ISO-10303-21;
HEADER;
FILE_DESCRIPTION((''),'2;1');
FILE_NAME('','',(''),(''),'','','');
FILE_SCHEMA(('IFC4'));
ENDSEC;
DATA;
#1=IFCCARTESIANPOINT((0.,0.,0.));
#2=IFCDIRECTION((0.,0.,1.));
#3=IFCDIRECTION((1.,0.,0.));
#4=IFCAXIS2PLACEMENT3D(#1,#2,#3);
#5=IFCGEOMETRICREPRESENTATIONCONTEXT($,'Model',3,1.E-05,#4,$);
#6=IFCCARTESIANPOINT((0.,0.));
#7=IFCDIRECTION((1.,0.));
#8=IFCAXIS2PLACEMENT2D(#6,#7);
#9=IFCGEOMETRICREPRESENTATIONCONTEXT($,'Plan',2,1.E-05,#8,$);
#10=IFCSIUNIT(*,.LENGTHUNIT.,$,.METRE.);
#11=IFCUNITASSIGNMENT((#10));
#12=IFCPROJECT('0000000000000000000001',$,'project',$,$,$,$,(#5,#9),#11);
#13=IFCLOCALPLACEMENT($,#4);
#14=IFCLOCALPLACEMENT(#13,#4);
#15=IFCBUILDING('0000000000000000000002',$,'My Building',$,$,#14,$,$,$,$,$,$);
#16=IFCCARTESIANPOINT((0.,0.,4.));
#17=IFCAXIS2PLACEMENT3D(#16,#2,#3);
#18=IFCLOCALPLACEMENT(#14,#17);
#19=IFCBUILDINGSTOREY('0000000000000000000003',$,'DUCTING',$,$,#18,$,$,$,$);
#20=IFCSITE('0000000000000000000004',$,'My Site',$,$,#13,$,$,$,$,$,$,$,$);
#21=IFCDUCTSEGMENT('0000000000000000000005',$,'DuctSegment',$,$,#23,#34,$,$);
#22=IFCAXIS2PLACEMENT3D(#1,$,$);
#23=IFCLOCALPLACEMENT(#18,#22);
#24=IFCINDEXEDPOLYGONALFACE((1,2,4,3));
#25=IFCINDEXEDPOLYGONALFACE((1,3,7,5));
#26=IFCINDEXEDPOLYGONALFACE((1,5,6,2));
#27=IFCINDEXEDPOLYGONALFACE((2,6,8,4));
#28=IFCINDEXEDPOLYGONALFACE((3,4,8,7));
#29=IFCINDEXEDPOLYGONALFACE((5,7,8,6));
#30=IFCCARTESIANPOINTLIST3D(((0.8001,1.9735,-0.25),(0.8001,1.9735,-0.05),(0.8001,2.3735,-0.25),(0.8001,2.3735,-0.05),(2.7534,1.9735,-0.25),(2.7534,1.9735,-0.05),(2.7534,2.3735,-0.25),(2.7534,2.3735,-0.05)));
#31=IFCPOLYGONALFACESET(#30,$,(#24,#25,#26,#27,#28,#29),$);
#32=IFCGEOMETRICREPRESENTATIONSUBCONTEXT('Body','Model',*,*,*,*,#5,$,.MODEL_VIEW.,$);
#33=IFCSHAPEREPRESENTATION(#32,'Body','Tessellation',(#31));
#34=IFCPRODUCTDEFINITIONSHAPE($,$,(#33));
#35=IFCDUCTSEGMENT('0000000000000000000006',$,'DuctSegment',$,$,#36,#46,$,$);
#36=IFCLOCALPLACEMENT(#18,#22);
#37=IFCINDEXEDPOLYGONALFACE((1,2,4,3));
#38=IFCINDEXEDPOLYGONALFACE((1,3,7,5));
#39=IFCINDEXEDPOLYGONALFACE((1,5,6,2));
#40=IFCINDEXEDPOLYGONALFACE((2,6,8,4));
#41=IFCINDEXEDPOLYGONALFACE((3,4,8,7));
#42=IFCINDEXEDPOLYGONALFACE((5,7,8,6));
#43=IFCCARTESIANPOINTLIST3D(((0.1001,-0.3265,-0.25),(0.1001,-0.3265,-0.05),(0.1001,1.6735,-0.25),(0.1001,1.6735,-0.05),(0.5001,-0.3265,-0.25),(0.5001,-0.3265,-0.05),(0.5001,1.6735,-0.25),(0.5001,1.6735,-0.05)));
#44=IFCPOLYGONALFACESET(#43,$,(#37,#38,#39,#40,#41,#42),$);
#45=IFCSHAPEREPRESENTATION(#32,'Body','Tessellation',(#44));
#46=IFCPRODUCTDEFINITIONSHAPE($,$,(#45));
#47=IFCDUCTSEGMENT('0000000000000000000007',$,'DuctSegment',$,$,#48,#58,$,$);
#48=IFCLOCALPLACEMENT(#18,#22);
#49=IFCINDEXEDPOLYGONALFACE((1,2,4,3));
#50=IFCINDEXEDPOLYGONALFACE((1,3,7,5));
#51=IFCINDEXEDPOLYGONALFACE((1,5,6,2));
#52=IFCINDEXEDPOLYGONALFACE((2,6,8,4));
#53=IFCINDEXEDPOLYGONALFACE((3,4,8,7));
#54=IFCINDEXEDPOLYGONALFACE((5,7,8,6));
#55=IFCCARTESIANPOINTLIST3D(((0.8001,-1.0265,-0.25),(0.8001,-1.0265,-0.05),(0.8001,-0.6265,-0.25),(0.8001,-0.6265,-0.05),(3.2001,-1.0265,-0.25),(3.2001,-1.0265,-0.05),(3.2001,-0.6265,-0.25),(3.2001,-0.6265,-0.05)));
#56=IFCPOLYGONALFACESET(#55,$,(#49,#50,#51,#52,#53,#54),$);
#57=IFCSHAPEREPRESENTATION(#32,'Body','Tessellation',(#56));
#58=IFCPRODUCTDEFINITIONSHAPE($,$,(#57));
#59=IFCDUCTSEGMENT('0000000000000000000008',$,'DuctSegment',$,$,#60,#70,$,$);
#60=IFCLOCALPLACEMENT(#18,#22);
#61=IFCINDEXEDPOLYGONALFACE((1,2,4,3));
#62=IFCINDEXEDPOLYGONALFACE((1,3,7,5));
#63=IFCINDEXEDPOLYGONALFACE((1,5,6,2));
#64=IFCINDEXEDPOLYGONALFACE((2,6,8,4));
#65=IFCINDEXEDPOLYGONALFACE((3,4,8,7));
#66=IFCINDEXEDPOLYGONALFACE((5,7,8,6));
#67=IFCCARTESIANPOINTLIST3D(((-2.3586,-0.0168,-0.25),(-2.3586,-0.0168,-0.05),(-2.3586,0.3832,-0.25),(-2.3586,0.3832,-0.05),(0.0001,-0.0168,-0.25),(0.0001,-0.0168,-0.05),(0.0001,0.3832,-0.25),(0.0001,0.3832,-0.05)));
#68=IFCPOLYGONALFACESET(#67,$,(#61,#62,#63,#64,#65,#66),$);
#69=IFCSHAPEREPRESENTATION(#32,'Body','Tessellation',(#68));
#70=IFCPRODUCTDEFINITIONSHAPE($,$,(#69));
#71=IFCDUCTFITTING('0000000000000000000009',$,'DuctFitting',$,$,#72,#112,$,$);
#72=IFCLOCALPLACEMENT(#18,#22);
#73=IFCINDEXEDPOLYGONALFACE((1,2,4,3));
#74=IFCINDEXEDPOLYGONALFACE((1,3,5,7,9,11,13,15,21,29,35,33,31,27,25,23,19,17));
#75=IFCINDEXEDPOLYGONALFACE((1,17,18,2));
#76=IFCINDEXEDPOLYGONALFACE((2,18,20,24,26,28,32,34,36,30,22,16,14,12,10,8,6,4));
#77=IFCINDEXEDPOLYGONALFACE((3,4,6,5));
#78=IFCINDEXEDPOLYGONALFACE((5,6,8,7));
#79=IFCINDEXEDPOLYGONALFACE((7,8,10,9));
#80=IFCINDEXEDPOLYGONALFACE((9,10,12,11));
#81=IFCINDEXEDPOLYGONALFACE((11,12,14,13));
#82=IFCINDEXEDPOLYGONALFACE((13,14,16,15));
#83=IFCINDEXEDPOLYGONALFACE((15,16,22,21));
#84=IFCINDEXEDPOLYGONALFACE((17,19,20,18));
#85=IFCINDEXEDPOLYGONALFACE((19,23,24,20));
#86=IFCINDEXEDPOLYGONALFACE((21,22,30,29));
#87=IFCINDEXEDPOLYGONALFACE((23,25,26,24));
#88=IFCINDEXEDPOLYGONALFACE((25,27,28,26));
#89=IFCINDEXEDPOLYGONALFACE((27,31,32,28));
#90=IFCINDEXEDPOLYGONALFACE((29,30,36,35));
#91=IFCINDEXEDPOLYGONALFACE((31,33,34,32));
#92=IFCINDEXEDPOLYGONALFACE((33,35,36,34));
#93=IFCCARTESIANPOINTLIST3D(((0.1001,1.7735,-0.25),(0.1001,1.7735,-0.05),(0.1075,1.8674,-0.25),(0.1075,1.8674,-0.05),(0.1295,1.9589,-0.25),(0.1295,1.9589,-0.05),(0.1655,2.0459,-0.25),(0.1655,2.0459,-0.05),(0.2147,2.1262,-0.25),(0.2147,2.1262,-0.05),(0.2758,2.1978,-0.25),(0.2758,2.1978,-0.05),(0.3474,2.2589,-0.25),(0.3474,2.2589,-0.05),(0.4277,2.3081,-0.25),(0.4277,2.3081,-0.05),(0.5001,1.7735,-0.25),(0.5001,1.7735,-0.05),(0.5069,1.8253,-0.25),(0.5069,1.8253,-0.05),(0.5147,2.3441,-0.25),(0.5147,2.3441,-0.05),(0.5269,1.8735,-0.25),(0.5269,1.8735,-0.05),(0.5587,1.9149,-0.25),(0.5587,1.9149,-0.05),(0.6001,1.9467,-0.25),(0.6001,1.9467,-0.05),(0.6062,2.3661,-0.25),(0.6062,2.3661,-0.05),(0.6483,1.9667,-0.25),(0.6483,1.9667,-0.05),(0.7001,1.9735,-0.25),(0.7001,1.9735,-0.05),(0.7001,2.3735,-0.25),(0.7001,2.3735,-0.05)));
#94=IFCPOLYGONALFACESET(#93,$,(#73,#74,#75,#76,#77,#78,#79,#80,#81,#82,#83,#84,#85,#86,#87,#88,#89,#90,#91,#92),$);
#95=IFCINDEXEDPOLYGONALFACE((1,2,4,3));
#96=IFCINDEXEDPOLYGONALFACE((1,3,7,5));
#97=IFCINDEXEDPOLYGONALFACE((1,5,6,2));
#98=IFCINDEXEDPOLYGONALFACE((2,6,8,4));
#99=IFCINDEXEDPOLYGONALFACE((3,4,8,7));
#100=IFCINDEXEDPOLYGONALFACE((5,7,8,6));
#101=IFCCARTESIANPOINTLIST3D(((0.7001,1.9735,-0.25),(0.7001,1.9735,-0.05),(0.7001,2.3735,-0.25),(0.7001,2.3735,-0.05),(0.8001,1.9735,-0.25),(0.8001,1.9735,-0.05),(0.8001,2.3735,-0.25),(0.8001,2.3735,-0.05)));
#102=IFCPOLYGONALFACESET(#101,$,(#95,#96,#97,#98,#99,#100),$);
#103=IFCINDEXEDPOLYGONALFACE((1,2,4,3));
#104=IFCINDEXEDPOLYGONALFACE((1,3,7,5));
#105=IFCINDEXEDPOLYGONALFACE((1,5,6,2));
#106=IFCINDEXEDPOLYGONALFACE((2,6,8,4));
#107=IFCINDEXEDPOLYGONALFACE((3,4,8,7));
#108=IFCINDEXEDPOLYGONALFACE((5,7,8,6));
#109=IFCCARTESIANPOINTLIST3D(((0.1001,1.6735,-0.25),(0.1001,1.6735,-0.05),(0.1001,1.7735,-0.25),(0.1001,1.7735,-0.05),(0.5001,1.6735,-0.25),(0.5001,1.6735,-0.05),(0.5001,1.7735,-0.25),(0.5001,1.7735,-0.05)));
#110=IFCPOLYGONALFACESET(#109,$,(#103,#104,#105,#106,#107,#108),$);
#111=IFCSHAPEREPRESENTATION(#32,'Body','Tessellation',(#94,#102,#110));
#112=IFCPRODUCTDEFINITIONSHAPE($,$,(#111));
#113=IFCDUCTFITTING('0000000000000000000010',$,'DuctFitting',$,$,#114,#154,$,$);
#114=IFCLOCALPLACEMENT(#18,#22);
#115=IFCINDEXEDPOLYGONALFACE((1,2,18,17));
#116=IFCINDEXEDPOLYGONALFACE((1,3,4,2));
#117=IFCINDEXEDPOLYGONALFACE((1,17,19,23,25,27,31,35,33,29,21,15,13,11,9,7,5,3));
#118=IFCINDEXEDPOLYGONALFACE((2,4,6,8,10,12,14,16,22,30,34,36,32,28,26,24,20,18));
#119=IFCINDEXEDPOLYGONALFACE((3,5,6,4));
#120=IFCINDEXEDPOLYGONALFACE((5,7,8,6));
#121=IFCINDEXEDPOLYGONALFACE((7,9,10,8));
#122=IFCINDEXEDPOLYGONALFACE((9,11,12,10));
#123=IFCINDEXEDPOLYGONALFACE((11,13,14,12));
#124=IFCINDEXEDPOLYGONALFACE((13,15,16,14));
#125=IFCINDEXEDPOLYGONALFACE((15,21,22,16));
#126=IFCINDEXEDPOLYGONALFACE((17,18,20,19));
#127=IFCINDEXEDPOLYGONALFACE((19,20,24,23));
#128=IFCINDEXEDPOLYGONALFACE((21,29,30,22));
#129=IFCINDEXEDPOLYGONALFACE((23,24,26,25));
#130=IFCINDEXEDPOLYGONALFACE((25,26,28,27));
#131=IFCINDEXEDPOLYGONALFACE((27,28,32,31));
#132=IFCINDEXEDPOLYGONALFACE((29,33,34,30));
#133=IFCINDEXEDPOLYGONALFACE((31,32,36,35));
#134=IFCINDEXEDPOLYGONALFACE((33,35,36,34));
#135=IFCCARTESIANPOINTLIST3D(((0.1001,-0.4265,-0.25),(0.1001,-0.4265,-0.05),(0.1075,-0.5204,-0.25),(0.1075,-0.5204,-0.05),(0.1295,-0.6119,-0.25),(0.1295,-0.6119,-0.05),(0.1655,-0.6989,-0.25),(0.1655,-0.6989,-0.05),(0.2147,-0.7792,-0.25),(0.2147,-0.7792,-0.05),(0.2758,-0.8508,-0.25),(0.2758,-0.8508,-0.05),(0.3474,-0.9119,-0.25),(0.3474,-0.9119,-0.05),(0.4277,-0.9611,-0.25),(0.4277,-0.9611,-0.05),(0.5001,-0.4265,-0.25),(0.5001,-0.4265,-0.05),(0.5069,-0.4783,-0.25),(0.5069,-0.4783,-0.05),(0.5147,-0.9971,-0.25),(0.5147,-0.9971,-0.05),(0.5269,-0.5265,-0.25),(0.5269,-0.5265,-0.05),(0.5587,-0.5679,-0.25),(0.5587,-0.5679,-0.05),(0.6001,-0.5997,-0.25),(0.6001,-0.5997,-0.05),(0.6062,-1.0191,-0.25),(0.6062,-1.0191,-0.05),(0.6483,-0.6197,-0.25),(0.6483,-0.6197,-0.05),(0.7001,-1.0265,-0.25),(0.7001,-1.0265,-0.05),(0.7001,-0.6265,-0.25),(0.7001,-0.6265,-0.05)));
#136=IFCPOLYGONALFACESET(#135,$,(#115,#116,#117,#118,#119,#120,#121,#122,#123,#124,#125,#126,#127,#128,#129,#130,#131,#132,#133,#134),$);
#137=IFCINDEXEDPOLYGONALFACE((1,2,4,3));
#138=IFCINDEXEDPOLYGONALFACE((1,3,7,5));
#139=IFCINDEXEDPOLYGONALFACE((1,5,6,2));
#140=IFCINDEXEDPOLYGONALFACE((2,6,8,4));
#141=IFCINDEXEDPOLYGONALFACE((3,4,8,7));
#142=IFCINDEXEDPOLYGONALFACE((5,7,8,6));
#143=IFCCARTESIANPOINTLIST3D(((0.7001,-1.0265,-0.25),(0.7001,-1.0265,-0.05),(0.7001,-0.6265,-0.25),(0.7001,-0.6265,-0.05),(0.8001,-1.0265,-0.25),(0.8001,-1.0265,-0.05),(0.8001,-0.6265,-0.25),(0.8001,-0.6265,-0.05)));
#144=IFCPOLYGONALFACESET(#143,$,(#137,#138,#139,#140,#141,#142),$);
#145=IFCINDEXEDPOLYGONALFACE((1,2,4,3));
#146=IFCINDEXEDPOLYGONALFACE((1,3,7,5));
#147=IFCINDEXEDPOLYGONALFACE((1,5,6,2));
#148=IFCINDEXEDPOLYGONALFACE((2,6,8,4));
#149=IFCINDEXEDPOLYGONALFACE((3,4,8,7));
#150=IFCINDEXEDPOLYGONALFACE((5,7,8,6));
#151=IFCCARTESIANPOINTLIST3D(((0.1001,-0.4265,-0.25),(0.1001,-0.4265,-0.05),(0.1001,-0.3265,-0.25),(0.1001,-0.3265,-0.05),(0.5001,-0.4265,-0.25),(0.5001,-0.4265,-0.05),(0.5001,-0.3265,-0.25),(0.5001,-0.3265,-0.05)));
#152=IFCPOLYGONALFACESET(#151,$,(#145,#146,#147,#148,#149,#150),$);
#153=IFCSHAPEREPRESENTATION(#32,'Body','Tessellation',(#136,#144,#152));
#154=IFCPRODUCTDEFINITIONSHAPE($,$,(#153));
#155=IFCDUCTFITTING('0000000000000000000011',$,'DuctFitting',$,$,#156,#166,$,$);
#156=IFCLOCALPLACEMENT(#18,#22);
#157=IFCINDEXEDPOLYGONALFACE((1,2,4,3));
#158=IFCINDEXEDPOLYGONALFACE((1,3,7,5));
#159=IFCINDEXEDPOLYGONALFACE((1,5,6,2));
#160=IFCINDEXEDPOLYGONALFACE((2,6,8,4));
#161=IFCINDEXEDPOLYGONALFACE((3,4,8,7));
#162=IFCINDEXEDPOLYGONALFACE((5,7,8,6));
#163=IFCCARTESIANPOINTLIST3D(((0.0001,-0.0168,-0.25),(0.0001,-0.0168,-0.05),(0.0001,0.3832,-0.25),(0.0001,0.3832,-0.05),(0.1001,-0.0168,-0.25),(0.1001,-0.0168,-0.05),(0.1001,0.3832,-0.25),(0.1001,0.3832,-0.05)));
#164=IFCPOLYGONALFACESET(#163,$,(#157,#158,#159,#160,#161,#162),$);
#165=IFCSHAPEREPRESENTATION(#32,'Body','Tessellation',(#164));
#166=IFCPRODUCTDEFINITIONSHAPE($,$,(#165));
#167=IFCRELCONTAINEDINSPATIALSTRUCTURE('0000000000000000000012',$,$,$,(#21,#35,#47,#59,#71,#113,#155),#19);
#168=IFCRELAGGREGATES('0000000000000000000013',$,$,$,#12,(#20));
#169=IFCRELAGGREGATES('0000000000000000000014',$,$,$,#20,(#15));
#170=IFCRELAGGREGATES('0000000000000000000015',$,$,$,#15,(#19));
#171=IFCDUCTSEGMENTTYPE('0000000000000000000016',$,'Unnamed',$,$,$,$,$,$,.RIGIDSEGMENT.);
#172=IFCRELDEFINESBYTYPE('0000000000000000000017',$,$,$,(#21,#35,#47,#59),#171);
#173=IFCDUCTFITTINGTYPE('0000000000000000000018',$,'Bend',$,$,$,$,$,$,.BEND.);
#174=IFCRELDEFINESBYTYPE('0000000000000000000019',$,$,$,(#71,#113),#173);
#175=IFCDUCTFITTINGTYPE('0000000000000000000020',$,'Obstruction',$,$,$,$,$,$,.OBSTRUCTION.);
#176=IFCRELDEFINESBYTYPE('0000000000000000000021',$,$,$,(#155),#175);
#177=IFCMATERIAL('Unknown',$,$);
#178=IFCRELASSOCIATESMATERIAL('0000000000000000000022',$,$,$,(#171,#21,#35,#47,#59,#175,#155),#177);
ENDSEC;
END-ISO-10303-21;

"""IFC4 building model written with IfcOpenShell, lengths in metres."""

from ifc_helpers import new_model, si_unit, frame, origin_with_axes, origin_2d_with_axis, place, context, subcontext, project, spatial, line, arc, indexed_curve, rectangle, outline, extrude, source, transform, mapped, material, material_profile, profile_set, profile_usage, type_object, type_shapes, element, save


model = new_model("IFC4")

# Units and contexts
model_context = context("Model", 3, precision=1e-05, world=origin_with_axes())
plan_context = context("Plan", 2, precision=1e-05, world=origin_2d_with_axis())
body_context = subcontext(model_context, "Body", "Model", "MODEL_VIEW")
ifc_project = project(units=[si_unit("LENGTHUNIT", "METRE")], contexts=[model_context, plan_context])

# Site, building, storey
site_placement = place(None, origin_with_axes())
site = spatial("IfcSite", under=ifc_project, at=site_placement, Name="My Site")
building_placement = place(site_placement, origin_with_axes())
building = spatial("IfcBuilding", under=site, at=building_placement, Name="My Building")
storey_placement = place(building_placement, frame((0.0, 0.0, 4.0), z_axis=(0.0, 0.0, 1.0), x_axis=(1.0, 0.0, 0.0)))
storey = spatial("IfcBuildingStorey", under=building, at=storey_placement, Name="DUCTING")

# Duct segments
ifc_material = material(Name="Unknown")
ifc_material_profile_1 = material_profile(ifc_material, rectangle(XDim=0.4, YDim=0.2))
ifc_profile_set_1 = profile_set([ifc_material_profile_1])
ifc_profile_usage_1 = profile_usage(ifc_profile_set_1, cardinal=5)
duct_segment_type = type_object("IfcDuctSegmentType", Name="Unnamed", PredefinedType="RIGIDSEGMENT", material=ifc_profile_set_1)
duct_segment_1_placement = place(storey_placement, frame((2.7534, 2.1735, -0.15), z_axis=(-1.0, 0.0, 0.0), x_axis=(0.0, -1.0, 0.0)))
element("IfcDuctSegment", 1, at=duct_segment_1_placement, inside=storey, type_object=duct_segment_type, material=ifc_profile_usage_1, Name="DuctSegment", context=body_context, shape_type="SweptSolid", body=[
    extrude(rectangle(XDim=0.4, YDim=0.2), origin_with_axes(), (0.0, 0.0, 1.0), 1.9533),
])
ifc_profile_usage_2 = profile_usage(ifc_profile_set_1, cardinal=5)
duct_segment_2_placement = place(storey_placement, frame((0.3001, 1.6735, -0.15), z_axis=(0.0, -1.0, 0.0), x_axis=(1.0, 0.0, 0.0)))
element("IfcDuctSegment", 2, at=duct_segment_2_placement, inside=storey, type_object=duct_segment_type, material=ifc_profile_usage_2, Name="DuctSegment", context=body_context, shape_type="SweptSolid", body=[
    extrude(rectangle(XDim=0.4, YDim=0.2), origin_with_axes(), (0.0, 0.0, 1.0), 2.0),
])
ifc_profile_usage_3 = profile_usage(ifc_profile_set_1, cardinal=5)
duct_segment_3_placement = place(storey_placement, frame((0.8001, -0.8265, -0.15), z_axis=(1.0, -0.000001, 0.000001), x_axis=(0.000001, 1.0, 0.0)))
element("IfcDuctSegment", 3, at=duct_segment_3_placement, inside=storey, type_object=duct_segment_type, material=ifc_profile_usage_3, Name="DuctSegment", context=body_context, shape_type="SweptSolid", body=[
    extrude(rectangle(XDim=0.4, YDim=0.2), origin_with_axes(), (0.0, 0.0, 1.0), 2.4),
])
ifc_profile_usage_4 = profile_usage(ifc_profile_set_1, cardinal=5)
duct_segment_4_placement = place(storey_placement, frame((-2.3586, 0.1832, -0.15), z_axis=(1.0, -0.000001, 0.000001), x_axis=(0.000001, 1.0, 0.0)))
element("IfcDuctSegment", 4, at=duct_segment_4_placement, inside=storey, type_object=duct_segment_type, material=ifc_profile_usage_4, Name="DuctSegment", context=body_context, shape_type="SweptSolid", body=[
    extrude(rectangle(XDim=0.4, YDim=0.2), origin_with_axes(), (0.0, 0.0, 1.0), 2.3587),
])

# Duct fittings
duct_fitting_type_1 = type_object("IfcDuctFittingType", Name="Bend", PredefinedType="BEND")
shared_shape = source(origin_with_axes(), body_context, "Body", "SweptSolid", [
    extrude(outline(indexed_curve([(0.2, 0.0), (0.2586, 0.1414), (0.4, 0.2), (0.4, 0.6), (-0.0243, 0.4243), (-0.2, 0.0)], segments=[arc(1, 2, 3), line(3, 4), arc(4, 5, 6), line(6, 1)])), frame((0.0, -0.1, 0.1), z_axis=(0.0, -1.0, 0.0), x_axis=(1.0, 0.0, 0.0)), (0.0, 0.0, -1.0), 0.2),
    extrude(rectangle(XDim=0.4, YDim=0.2), origin_with_axes(), (0.0, 0.0, 1.0), 0.1),
    extrude(rectangle(XDim=0.4, YDim=0.2), frame((0.4, 0.0, 0.5), z_axis=(1.0, 0.0, 0.0), x_axis=(0.0, 0.0, 1.0)), (0.0, 0.0, 1.0), 0.1),
])
type_shapes(duct_fitting_type_1, [shared_shape])
for number, where, z_axis, x_axis, name in (
    (5, (0.8001, 2.1735, -0.15), (-1.0, 0.0, 0.0), (0.0, -1.0, 0.0), "DuctFitting"),
    (6, (0.8001, -0.8265, -0.15), (-1.0, 0.000001, -0.000001), (0.000001, 1.0, 0.0), "DuctFitting"),
):
    element("IfcDuctFitting", number, at=place(storey_placement, frame(where, z_axis=z_axis, x_axis=x_axis)), inside=storey, type_object=duct_fitting_type_1, Name=name, context=body_context, shape_type="MappedRepresentation", body=[
        mapped(shared_shape, transform((0.0, 0.0, 0.0), x_axis=(1.0, 0.0, 0.0), y_axis=(0.0, 1.0, 0.0), z_axis=(0.0, 0.0, 1.0), scale=1.0)),
    ])
ifc_material_profile_2 = material_profile(ifc_material, rectangle(XDim=0.4, YDim=0.2))
ifc_profile_set_2 = profile_set([ifc_material_profile_2])
ifc_profile_usage_5 = profile_usage(ifc_profile_set_2, cardinal=5)
duct_fitting_type_2 = type_object("IfcDuctFittingType", Name="Obstruction", PredefinedType="OBSTRUCTION", material=ifc_profile_set_2)
duct_fitting_placement = place(storey_placement, frame((0.0001, 0.1832, -0.15), z_axis=(1.0, -0.000001, 0.000001), x_axis=(0.000001, 1.0, 0.0)))
element("IfcDuctFitting", 7, at=duct_fitting_placement, inside=storey, type_object=duct_fitting_type_2, material=ifc_profile_usage_5, Name="DuctFitting", context=body_context, shape_type="SweptSolid", body=[
    extrude(rectangle(XDim=0.4, YDim=0.2), origin_with_axes(), (0.0, 0.0, 1.0), 0.1),
])

save(model, "model.ifc")
